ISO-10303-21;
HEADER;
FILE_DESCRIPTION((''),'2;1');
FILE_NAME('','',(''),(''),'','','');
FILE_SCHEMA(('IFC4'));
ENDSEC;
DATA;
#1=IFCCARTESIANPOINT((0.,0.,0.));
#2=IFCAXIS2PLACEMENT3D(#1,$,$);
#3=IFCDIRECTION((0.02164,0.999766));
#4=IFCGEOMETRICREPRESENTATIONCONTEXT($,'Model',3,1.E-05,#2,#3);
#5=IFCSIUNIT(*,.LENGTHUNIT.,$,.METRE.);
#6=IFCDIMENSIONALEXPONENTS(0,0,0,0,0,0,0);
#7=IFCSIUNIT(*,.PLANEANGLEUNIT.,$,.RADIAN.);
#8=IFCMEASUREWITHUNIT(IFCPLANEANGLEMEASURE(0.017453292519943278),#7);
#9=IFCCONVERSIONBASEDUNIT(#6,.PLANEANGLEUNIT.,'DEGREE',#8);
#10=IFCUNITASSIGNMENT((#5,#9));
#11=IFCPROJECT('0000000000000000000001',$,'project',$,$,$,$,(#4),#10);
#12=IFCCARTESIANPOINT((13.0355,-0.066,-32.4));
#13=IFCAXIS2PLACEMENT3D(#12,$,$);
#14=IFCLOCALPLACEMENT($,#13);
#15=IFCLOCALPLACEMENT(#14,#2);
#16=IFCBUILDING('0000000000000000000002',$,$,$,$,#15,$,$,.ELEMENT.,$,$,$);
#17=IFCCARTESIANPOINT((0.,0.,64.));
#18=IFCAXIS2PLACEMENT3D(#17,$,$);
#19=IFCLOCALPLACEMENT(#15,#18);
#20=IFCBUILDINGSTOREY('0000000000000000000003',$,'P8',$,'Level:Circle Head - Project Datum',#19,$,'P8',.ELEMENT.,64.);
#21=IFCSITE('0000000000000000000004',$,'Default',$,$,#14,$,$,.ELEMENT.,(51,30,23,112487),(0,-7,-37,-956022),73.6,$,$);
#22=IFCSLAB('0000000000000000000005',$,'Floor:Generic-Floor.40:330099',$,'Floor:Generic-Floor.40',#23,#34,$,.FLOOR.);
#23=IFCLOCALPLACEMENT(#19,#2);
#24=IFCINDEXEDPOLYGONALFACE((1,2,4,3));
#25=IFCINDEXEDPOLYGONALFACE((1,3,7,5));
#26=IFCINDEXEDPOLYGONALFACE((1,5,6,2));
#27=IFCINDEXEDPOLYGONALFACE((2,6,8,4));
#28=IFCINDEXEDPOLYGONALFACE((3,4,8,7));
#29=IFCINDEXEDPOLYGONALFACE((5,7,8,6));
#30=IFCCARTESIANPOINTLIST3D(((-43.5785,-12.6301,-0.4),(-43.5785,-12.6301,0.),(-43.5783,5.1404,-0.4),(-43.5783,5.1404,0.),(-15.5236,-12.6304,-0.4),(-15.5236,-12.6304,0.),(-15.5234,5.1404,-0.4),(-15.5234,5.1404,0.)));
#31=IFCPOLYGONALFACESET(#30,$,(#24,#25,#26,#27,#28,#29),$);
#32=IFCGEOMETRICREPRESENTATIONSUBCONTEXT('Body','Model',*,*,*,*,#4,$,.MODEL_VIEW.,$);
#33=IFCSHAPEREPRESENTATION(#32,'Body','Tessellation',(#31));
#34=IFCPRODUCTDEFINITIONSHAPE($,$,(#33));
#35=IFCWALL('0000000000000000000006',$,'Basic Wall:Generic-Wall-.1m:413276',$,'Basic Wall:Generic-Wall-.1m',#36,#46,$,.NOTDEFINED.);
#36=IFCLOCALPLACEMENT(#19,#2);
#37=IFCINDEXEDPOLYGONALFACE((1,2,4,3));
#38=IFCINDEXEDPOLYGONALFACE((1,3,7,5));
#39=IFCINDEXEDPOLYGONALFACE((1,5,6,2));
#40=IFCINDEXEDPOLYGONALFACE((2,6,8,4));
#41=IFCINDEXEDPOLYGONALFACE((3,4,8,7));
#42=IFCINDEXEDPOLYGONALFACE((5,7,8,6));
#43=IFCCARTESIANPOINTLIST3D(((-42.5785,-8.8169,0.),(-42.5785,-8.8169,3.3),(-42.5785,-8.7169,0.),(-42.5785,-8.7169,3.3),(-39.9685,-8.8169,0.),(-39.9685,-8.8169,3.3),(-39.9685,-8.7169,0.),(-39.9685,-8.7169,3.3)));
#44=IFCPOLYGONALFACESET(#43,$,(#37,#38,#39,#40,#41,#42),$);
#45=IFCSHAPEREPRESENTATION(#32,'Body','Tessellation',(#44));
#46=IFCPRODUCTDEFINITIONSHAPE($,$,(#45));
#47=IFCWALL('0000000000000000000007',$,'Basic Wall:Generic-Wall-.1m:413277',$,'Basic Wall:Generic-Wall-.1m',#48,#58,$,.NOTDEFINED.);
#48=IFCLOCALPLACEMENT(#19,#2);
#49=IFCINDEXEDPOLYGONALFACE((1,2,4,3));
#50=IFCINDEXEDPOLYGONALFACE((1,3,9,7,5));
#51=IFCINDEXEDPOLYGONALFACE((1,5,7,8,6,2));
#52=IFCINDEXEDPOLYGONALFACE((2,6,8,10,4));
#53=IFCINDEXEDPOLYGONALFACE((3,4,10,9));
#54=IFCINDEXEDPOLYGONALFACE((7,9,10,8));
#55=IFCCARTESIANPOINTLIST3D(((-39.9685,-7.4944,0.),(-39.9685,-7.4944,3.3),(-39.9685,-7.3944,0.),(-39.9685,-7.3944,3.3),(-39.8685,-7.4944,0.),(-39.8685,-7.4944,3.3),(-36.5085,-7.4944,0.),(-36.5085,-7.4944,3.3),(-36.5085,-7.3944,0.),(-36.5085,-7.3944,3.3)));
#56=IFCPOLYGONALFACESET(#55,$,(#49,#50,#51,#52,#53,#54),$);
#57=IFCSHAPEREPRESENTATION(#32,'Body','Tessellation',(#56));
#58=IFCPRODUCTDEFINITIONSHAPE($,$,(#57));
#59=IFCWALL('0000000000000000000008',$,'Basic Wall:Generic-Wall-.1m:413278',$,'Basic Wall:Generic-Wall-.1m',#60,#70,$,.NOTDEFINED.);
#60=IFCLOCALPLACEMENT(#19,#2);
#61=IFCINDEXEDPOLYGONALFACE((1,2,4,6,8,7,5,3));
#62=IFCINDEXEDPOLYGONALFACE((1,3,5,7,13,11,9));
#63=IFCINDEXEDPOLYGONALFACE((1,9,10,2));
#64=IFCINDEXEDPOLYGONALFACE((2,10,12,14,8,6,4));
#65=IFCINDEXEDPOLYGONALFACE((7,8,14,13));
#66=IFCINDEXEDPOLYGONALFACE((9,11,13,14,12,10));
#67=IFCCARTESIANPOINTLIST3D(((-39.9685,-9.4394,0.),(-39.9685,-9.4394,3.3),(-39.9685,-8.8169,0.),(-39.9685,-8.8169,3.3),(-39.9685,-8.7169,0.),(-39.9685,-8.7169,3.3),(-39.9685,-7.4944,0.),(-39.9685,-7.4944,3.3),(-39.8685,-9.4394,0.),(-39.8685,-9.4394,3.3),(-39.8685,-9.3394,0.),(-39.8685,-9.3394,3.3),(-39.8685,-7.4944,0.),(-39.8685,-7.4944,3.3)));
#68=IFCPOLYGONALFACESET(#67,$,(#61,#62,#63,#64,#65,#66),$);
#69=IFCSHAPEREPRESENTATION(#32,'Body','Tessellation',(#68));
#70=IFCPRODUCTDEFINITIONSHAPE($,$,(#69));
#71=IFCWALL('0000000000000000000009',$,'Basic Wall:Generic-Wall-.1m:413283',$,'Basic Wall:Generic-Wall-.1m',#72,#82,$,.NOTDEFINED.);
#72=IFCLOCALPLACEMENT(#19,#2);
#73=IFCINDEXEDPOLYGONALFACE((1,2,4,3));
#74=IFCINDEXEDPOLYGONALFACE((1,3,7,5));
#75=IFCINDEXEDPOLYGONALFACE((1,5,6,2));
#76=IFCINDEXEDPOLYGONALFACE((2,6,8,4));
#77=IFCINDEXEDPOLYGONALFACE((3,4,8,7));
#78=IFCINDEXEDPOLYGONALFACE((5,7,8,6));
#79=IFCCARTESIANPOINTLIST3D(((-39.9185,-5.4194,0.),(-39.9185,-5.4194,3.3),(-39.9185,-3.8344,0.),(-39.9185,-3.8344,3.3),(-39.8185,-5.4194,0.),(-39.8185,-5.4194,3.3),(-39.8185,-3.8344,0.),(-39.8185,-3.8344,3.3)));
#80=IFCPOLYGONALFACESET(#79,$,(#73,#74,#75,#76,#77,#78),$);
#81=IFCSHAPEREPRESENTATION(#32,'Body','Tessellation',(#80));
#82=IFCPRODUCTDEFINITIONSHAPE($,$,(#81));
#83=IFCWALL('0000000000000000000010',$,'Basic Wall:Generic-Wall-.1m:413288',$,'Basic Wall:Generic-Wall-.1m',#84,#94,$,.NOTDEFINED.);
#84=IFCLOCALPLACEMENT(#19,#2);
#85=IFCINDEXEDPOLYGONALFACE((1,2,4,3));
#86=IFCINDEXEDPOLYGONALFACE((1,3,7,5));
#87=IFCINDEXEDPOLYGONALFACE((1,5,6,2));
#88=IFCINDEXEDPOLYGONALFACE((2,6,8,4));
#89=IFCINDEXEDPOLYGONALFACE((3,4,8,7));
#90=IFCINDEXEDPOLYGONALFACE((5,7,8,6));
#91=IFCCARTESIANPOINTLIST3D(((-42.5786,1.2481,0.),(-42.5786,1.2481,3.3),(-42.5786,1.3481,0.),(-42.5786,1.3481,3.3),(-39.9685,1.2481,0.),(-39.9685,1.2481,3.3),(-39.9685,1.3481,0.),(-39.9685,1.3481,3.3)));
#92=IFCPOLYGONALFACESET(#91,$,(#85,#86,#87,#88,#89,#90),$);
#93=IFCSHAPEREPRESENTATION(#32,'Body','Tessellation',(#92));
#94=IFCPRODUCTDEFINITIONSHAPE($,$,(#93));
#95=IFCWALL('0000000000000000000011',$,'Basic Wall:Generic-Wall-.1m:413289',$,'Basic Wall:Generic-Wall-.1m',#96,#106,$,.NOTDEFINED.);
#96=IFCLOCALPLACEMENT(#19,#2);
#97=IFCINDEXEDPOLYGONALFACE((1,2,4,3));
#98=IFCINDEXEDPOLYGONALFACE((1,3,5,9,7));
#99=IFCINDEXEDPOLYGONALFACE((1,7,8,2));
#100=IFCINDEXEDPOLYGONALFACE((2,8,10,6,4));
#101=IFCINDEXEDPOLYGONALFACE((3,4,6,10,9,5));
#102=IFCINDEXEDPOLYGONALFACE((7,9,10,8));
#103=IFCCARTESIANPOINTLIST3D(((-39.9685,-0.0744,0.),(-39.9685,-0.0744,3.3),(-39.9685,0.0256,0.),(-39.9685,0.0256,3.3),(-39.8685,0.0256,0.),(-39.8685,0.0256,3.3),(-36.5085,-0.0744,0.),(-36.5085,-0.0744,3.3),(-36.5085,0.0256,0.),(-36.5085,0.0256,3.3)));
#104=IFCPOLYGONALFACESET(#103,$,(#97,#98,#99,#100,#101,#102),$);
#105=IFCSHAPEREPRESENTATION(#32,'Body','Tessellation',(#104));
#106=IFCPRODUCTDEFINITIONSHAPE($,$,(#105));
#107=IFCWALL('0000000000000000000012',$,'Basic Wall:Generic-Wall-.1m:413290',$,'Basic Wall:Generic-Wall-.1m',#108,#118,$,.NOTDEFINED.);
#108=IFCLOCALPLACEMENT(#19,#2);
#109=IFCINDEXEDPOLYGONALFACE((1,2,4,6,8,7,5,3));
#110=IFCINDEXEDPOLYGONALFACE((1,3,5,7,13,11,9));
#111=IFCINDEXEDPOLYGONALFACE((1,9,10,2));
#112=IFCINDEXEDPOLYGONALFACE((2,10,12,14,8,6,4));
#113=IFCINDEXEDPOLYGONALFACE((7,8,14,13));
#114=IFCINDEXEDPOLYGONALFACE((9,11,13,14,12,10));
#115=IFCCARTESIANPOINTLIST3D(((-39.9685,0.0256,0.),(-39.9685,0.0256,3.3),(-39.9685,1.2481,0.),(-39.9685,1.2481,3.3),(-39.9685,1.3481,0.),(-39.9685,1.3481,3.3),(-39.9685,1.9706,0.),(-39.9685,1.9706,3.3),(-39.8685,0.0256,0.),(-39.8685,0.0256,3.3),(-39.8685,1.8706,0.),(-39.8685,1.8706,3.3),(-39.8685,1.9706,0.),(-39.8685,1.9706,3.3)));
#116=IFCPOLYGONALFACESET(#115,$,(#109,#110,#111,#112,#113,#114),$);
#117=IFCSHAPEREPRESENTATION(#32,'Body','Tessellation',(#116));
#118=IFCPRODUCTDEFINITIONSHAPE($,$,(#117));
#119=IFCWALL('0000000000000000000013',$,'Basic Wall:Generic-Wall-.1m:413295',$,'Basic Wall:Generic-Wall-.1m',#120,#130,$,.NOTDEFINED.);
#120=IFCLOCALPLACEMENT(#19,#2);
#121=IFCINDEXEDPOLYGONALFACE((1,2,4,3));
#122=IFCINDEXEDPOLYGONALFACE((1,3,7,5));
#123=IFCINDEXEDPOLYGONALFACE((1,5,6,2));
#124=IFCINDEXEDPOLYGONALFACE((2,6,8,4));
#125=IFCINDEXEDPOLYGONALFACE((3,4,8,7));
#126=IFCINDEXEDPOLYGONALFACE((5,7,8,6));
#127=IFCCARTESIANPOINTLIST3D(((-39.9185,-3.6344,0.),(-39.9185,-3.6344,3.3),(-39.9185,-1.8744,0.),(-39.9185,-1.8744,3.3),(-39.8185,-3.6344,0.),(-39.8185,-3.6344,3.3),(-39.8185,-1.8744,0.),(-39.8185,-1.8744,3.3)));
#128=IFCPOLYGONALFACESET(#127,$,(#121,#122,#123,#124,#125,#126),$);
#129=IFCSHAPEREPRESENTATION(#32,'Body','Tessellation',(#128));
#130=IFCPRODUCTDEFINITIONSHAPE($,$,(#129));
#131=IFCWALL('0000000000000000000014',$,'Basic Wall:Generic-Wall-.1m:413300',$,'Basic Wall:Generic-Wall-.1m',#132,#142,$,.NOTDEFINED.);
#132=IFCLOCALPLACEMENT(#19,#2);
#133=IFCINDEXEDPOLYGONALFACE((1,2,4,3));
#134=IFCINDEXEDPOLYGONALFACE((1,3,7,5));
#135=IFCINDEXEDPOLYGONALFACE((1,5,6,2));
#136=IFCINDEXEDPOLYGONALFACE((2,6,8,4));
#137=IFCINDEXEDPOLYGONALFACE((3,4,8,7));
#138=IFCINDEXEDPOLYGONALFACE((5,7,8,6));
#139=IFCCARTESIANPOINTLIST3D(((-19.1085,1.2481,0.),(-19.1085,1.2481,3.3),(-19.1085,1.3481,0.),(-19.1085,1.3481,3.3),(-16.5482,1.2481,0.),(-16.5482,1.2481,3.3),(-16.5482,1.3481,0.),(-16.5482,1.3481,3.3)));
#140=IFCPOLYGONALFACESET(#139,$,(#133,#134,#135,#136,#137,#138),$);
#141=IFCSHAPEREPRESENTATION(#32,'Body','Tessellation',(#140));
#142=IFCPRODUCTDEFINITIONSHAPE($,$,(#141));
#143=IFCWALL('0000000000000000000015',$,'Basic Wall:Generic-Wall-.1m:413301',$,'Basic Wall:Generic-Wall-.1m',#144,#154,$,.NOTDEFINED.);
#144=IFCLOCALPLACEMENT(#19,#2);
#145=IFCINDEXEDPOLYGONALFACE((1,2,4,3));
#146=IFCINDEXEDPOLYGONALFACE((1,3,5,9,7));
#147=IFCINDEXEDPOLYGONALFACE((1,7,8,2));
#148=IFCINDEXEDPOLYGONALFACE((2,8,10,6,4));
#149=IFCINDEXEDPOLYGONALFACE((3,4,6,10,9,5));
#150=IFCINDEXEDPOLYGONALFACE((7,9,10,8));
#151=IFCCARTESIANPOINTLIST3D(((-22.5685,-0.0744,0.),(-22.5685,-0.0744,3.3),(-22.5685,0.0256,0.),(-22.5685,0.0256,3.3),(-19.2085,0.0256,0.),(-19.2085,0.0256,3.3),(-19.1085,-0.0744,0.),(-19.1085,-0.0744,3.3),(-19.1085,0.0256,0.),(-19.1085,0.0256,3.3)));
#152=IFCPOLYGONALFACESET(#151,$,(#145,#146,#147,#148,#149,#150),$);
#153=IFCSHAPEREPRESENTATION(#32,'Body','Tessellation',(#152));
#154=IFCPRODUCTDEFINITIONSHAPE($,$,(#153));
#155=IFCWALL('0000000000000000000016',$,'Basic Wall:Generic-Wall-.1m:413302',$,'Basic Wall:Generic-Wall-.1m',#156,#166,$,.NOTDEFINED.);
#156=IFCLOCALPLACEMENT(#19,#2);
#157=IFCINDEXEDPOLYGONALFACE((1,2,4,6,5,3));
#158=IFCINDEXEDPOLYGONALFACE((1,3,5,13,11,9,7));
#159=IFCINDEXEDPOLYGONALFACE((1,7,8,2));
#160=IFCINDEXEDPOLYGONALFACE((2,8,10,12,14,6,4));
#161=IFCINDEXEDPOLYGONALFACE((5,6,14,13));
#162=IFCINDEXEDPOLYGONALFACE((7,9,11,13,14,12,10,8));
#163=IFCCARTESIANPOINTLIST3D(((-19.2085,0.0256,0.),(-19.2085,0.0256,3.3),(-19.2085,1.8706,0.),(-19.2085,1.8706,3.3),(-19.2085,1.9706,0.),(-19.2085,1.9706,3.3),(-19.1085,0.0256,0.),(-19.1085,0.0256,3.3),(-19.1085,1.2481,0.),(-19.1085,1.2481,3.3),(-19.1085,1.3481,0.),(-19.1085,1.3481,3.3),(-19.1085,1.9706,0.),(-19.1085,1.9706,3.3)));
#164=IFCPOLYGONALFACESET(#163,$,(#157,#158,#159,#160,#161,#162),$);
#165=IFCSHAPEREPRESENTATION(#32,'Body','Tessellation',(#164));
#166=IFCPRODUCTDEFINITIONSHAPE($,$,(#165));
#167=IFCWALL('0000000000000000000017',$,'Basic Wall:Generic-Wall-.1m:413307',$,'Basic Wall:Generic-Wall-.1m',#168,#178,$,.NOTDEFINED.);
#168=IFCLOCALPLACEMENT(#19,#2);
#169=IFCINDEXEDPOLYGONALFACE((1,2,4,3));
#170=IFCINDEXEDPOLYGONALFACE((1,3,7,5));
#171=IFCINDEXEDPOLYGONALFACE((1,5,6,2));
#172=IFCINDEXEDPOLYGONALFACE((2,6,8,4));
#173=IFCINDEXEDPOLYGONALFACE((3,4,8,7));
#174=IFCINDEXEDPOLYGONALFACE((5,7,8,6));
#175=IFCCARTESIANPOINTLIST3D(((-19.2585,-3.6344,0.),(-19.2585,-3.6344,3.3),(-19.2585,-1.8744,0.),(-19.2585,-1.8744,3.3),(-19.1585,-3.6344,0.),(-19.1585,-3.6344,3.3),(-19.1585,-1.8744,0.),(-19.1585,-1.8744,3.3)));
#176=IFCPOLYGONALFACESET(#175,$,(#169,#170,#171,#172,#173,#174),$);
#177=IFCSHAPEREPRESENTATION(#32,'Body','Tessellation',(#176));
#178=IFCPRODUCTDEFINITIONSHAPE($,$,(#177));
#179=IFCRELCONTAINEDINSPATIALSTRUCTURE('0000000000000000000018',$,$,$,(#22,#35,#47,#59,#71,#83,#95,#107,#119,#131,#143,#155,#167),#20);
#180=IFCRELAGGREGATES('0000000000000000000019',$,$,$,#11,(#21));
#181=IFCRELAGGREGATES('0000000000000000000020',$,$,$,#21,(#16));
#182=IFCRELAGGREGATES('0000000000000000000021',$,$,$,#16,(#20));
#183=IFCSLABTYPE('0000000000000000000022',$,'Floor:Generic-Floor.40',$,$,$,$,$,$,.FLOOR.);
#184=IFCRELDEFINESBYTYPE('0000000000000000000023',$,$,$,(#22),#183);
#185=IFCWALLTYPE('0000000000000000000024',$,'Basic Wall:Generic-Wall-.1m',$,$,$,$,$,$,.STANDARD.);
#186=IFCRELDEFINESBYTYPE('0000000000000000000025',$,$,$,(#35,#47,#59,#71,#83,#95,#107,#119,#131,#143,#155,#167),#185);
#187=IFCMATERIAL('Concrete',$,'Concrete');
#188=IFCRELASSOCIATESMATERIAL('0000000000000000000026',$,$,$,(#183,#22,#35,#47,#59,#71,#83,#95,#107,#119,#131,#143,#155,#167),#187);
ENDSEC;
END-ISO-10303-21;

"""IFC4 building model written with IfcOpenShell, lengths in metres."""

from ifc_helpers import new_model, entity, si_unit, converted_unit, direction, frame, origin, place, context, subcontext, project, spatial, indexed_curve, outline, extrude, material, type_object, element, save


model = new_model("IFC4")

# Units and contexts
model_context = context("Model", 3, precision=1e-05, world=origin(), true_north=direction((0.02164, 0.999766)))
body_context = subcontext(model_context, "Body", "Model", "MODEL_VIEW")
ifc_project = project(units=[si_unit("LENGTHUNIT", "METRE"), converted_unit("PLANEANGLEUNIT", "DEGREE", entity("IfcPlaneAngleMeasure", 0.017453292519943278), si_unit("PLANEANGLEUNIT", "RADIAN"), dimensions=[0, 0, 0, 0, 0, 0, 0])], contexts=[model_context])

# Site, building, storey
site_placement = place(None, frame((13.0355, -0.066, -32.4)))
site = spatial("IfcSite", under=ifc_project, at=site_placement, Name="Default", CompositionType="ELEMENT", RefLatitude=(51, 30, 23, 112487), RefLongitude=(0, -7, -37, -956022), RefElevation=73.6)
building_placement = place(site_placement, origin())
building = spatial("IfcBuilding", under=site, at=building_placement, CompositionType="ELEMENT")
storey_placement = place(building_placement, frame((0.0, 0.0, 64.0)))
storey = spatial("IfcBuildingStorey", under=building, at=storey_placement, Name="P8", ObjectType="Level:Circle Head - Project Datum", LongName="P8", CompositionType="ELEMENT", Elevation=64.0)

# Shared definitions
ifc_material = material(Name="Concrete", Category="Concrete")

# Slab
slab_type = type_object("IfcSlabType", Name="Floor:Generic-Floor.40", PredefinedType="FLOOR", material=ifc_material)
slab_placement = place(storey_placement, origin())
element("IfcSlab", 1, at=slab_placement, inside=storey, type_object=slab_type, material=ifc_material, Name="Floor:Generic-Floor.40:330099", ObjectType="Floor:Generic-Floor.40", PredefinedType="FLOOR", context=body_context, shape_type="SweptSolid", body=[
    extrude(outline(indexed_curve([(-14.0274, -8.8853), (14.0275, -8.8853), (14.0274, 8.8855), (-14.0275, 8.8852), (-14.0274, -8.8853)], self_intersect=False)), frame((-29.5509, -3.7449, 0.0), z_axis=(0.0, 0.0, -1.0), x_axis=(1.0, 0.0, 0.0)), (0.0, 0.0, 1.0), 0.4),
])

# Walls
wall_type = type_object("IfcWallType", Name="Basic Wall:Generic-Wall-.1m", PredefinedType="STANDARD")
wall_1_placement = place(storey_placement, frame((-39.9685, -8.7669, 0.0), z_axis=(0.0, 0.0, 1.0), x_axis=(-1.0, 0.0, 0.0)))
element("IfcWall", 2, at=wall_1_placement, inside=storey, type_object=wall_type, material=ifc_material, Name="Basic Wall:Generic-Wall-.1m:413276", ObjectType="Basic Wall:Generic-Wall-.1m", PredefinedType="NOTDEFINED", context=body_context, shape_type="SweptSolid", body=[
    extrude(outline(indexed_curve([(2.61, -0.05), (2.61, 0.05), (0.0, 0.05), (0.0, -0.05), (2.61, -0.05)], self_intersect=False)), origin(), (0.0, 0.0, 1.0), 3.3),
])
wall_2_placement = place(storey_placement, frame((-36.5085, -7.4444, 0.0), z_axis=(0.0, 0.0, 1.0), x_axis=(-1.0, 0.0, 0.0)))
element("IfcWall", 3, at=wall_2_placement, inside=storey, type_object=wall_type, material=ifc_material, Name="Basic Wall:Generic-Wall-.1m:413277", ObjectType="Basic Wall:Generic-Wall-.1m", PredefinedType="NOTDEFINED", context=body_context, shape_type="SweptSolid", body=[
    extrude(outline(indexed_curve([(3.46, -0.05), (3.46, 0.05), (3.36, 0.05), (0.0, 0.05), (0.0, -0.05), (3.46, -0.05)], self_intersect=False)), origin(), (0.0, 0.0, 1.0), 3.3),
])
wall_3_placement = place(storey_placement, frame((-39.9185, -7.4944, 0.0), z_axis=(0.0, 0.0, 1.0), x_axis=(0.0, -1.0, 0.0)))
element("IfcWall", 4, at=wall_3_placement, inside=storey, type_object=wall_type, material=ifc_material, Name="Basic Wall:Generic-Wall-.1m:413278", ObjectType="Basic Wall:Generic-Wall-.1m", PredefinedType="NOTDEFINED", context=body_context, shape_type="SweptSolid", body=[
    extrude(outline(indexed_curve([(1.945, -0.05), (1.945, 0.05), (1.845, 0.05), (0.0, 0.05), (0.0, -0.05), (1.2225, -0.05), (1.3225, -0.05), (1.945, -0.05)], self_intersect=False)), origin(), (0.0, 0.0, 1.0), 3.3),
])
wall_4_placement = place(storey_placement, frame((-39.8685, -5.4194, 0.0), z_axis=(0.0, 0.0, 1.0), x_axis=(0.0, 1.0, 0.0)))
element("IfcWall", 5, at=wall_4_placement, inside=storey, type_object=wall_type, material=ifc_material, Name="Basic Wall:Generic-Wall-.1m:413283", ObjectType="Basic Wall:Generic-Wall-.1m", PredefinedType="NOTDEFINED", context=body_context, shape_type="SweptSolid", body=[
    extrude(outline(indexed_curve([(1.585, -0.05), (1.585, 0.05), (0.0, 0.05), (0.0, -0.05), (1.585, -0.05)], self_intersect=False)), origin(), (0.0, 0.0, 1.0), 3.3),
])
wall_5_placement = place(storey_placement, frame((-39.9685, 1.2981, 0.0), z_axis=(0.0, 0.0, 1.0), x_axis=(-1.0, 0.0, 0.0)))
element("IfcWall", 6, at=wall_5_placement, inside=storey, type_object=wall_type, material=ifc_material, Name="Basic Wall:Generic-Wall-.1m:413288", ObjectType="Basic Wall:Generic-Wall-.1m", PredefinedType="NOTDEFINED", context=body_context, shape_type="SweptSolid", body=[
    extrude(outline(indexed_curve([(2.6101, -0.05), (2.6101, 0.05), (0.0, 0.05), (0.0, -0.05), (2.6101, -0.05)], self_intersect=False)), origin(), (0.0, 0.0, 1.0), 3.3),
])
wall_6_placement = place(storey_placement, frame((-36.5085, -0.0244, 0.0), z_axis=(0.0, 0.0, 1.0), x_axis=(-1.0, 0.0, 0.0)))
element("IfcWall", 7, at=wall_6_placement, inside=storey, type_object=wall_type, material=ifc_material, Name="Basic Wall:Generic-Wall-.1m:413289", ObjectType="Basic Wall:Generic-Wall-.1m", PredefinedType="NOTDEFINED", context=body_context, shape_type="SweptSolid", body=[
    extrude(outline(indexed_curve([(3.46, -0.05), (3.46, 0.05), (0.0, 0.05), (0.0, -0.05), (3.36, -0.05), (3.46, -0.05)], self_intersect=False)), origin(), (0.0, 0.0, 1.0), 3.3),
])
wall_7_placement = place(storey_placement, frame((-39.9185, 0.0256, 0.0), z_axis=(0.0, 0.0, 1.0), x_axis=(0.0, 1.0, 0.0)))
element("IfcWall", 8, at=wall_7_placement, inside=storey, type_object=wall_type, material=ifc_material, Name="Basic Wall:Generic-Wall-.1m:413290", ObjectType="Basic Wall:Generic-Wall-.1m", PredefinedType="NOTDEFINED", context=body_context, shape_type="SweptSolid", body=[
    extrude(outline(indexed_curve([(1.945, -0.05), (1.945, 0.05), (1.3225, 0.05), (1.2225, 0.05), (0.0, 0.05), (0.0, -0.05), (1.845, -0.05), (1.945, -0.05)], self_intersect=False)), origin(), (0.0, 0.0, 1.0), 3.3),
])
wall_8_placement = place(storey_placement, frame((-39.8685, -1.8744, 0.0), z_axis=(0.0, 0.0, 1.0), x_axis=(0.0, -1.0, 0.0)))
element("IfcWall", 9, at=wall_8_placement, inside=storey, type_object=wall_type, material=ifc_material, Name="Basic Wall:Generic-Wall-.1m:413295", ObjectType="Basic Wall:Generic-Wall-.1m", PredefinedType="NOTDEFINED", context=body_context, shape_type="SweptSolid", body=[
    extrude(outline(indexed_curve([(1.76, -0.05), (1.76, 0.05), (0.0, 0.05), (0.0, -0.05), (1.76, -0.05)], self_intersect=False)), origin(), (0.0, 0.0, 1.0), 3.3),
])
wall_9_placement = place(storey_placement, frame((-19.1085, 1.2981, 0.0)))
element("IfcWall", 10, at=wall_9_placement, inside=storey, type_object=wall_type, material=ifc_material, Name="Basic Wall:Generic-Wall-.1m:413300", ObjectType="Basic Wall:Generic-Wall-.1m", PredefinedType="NOTDEFINED", context=body_context, shape_type="SweptSolid", body=[
    extrude(outline(indexed_curve([(2.5602, -0.05), (2.5602, 0.05), (0.0, 0.05), (0.0, -0.05), (2.5602, -0.05)], self_intersect=False)), origin(), (0.0, 0.0, 1.0), 3.3),
])
wall_10_placement = place(storey_placement, frame((-22.5685, -0.0244, 0.0)))
element("IfcWall", 11, at=wall_10_placement, inside=storey, type_object=wall_type, material=ifc_material, Name="Basic Wall:Generic-Wall-.1m:413301", ObjectType="Basic Wall:Generic-Wall-.1m", PredefinedType="NOTDEFINED", context=body_context, shape_type="SweptSolid", body=[
    extrude(outline(indexed_curve([(3.46, -0.05), (3.46, 0.05), (3.36, 0.05), (0.0, 0.05), (0.0, -0.05), (3.46, -0.05)], self_intersect=False)), origin(), (0.0, 0.0, 1.0), 3.3),
])
wall_11_placement = place(storey_placement, frame((-19.1585, 0.0256, 0.0), z_axis=(0.0, 0.0, 1.0), x_axis=(0.0, 1.0, 0.0)))
element("IfcWall", 12, at=wall_11_placement, inside=storey, type_object=wall_type, material=ifc_material, Name="Basic Wall:Generic-Wall-.1m:413302", ObjectType="Basic Wall:Generic-Wall-.1m", PredefinedType="NOTDEFINED", context=body_context, shape_type="SweptSolid", body=[
    extrude(outline(indexed_curve([(1.945, -0.05), (1.945, 0.05), (1.845, 0.05), (0.0, 0.05), (0.0, -0.05), (1.2225, -0.05), (1.3225, -0.05), (1.945, -0.05)], self_intersect=False)), origin(), (0.0, 0.0, 1.0), 3.3),
])
wall_12_placement = place(storey_placement, frame((-19.2085, -1.8744, 0.0), z_axis=(0.0, 0.0, 1.0), x_axis=(0.0, -1.0, 0.0)))
element("IfcWall", 13, at=wall_12_placement, inside=storey, type_object=wall_type, material=ifc_material, Name="Basic Wall:Generic-Wall-.1m:413307", ObjectType="Basic Wall:Generic-Wall-.1m", PredefinedType="NOTDEFINED", context=body_context, shape_type="SweptSolid", body=[
    extrude(outline(indexed_curve([(1.76, -0.05), (1.76, 0.05), (0.0, 0.05), (0.0, -0.05), (1.76, -0.05)], self_intersect=False)), origin(), (0.0, 0.0, 1.0), 3.3),
])

save(model, "model.ifc")
